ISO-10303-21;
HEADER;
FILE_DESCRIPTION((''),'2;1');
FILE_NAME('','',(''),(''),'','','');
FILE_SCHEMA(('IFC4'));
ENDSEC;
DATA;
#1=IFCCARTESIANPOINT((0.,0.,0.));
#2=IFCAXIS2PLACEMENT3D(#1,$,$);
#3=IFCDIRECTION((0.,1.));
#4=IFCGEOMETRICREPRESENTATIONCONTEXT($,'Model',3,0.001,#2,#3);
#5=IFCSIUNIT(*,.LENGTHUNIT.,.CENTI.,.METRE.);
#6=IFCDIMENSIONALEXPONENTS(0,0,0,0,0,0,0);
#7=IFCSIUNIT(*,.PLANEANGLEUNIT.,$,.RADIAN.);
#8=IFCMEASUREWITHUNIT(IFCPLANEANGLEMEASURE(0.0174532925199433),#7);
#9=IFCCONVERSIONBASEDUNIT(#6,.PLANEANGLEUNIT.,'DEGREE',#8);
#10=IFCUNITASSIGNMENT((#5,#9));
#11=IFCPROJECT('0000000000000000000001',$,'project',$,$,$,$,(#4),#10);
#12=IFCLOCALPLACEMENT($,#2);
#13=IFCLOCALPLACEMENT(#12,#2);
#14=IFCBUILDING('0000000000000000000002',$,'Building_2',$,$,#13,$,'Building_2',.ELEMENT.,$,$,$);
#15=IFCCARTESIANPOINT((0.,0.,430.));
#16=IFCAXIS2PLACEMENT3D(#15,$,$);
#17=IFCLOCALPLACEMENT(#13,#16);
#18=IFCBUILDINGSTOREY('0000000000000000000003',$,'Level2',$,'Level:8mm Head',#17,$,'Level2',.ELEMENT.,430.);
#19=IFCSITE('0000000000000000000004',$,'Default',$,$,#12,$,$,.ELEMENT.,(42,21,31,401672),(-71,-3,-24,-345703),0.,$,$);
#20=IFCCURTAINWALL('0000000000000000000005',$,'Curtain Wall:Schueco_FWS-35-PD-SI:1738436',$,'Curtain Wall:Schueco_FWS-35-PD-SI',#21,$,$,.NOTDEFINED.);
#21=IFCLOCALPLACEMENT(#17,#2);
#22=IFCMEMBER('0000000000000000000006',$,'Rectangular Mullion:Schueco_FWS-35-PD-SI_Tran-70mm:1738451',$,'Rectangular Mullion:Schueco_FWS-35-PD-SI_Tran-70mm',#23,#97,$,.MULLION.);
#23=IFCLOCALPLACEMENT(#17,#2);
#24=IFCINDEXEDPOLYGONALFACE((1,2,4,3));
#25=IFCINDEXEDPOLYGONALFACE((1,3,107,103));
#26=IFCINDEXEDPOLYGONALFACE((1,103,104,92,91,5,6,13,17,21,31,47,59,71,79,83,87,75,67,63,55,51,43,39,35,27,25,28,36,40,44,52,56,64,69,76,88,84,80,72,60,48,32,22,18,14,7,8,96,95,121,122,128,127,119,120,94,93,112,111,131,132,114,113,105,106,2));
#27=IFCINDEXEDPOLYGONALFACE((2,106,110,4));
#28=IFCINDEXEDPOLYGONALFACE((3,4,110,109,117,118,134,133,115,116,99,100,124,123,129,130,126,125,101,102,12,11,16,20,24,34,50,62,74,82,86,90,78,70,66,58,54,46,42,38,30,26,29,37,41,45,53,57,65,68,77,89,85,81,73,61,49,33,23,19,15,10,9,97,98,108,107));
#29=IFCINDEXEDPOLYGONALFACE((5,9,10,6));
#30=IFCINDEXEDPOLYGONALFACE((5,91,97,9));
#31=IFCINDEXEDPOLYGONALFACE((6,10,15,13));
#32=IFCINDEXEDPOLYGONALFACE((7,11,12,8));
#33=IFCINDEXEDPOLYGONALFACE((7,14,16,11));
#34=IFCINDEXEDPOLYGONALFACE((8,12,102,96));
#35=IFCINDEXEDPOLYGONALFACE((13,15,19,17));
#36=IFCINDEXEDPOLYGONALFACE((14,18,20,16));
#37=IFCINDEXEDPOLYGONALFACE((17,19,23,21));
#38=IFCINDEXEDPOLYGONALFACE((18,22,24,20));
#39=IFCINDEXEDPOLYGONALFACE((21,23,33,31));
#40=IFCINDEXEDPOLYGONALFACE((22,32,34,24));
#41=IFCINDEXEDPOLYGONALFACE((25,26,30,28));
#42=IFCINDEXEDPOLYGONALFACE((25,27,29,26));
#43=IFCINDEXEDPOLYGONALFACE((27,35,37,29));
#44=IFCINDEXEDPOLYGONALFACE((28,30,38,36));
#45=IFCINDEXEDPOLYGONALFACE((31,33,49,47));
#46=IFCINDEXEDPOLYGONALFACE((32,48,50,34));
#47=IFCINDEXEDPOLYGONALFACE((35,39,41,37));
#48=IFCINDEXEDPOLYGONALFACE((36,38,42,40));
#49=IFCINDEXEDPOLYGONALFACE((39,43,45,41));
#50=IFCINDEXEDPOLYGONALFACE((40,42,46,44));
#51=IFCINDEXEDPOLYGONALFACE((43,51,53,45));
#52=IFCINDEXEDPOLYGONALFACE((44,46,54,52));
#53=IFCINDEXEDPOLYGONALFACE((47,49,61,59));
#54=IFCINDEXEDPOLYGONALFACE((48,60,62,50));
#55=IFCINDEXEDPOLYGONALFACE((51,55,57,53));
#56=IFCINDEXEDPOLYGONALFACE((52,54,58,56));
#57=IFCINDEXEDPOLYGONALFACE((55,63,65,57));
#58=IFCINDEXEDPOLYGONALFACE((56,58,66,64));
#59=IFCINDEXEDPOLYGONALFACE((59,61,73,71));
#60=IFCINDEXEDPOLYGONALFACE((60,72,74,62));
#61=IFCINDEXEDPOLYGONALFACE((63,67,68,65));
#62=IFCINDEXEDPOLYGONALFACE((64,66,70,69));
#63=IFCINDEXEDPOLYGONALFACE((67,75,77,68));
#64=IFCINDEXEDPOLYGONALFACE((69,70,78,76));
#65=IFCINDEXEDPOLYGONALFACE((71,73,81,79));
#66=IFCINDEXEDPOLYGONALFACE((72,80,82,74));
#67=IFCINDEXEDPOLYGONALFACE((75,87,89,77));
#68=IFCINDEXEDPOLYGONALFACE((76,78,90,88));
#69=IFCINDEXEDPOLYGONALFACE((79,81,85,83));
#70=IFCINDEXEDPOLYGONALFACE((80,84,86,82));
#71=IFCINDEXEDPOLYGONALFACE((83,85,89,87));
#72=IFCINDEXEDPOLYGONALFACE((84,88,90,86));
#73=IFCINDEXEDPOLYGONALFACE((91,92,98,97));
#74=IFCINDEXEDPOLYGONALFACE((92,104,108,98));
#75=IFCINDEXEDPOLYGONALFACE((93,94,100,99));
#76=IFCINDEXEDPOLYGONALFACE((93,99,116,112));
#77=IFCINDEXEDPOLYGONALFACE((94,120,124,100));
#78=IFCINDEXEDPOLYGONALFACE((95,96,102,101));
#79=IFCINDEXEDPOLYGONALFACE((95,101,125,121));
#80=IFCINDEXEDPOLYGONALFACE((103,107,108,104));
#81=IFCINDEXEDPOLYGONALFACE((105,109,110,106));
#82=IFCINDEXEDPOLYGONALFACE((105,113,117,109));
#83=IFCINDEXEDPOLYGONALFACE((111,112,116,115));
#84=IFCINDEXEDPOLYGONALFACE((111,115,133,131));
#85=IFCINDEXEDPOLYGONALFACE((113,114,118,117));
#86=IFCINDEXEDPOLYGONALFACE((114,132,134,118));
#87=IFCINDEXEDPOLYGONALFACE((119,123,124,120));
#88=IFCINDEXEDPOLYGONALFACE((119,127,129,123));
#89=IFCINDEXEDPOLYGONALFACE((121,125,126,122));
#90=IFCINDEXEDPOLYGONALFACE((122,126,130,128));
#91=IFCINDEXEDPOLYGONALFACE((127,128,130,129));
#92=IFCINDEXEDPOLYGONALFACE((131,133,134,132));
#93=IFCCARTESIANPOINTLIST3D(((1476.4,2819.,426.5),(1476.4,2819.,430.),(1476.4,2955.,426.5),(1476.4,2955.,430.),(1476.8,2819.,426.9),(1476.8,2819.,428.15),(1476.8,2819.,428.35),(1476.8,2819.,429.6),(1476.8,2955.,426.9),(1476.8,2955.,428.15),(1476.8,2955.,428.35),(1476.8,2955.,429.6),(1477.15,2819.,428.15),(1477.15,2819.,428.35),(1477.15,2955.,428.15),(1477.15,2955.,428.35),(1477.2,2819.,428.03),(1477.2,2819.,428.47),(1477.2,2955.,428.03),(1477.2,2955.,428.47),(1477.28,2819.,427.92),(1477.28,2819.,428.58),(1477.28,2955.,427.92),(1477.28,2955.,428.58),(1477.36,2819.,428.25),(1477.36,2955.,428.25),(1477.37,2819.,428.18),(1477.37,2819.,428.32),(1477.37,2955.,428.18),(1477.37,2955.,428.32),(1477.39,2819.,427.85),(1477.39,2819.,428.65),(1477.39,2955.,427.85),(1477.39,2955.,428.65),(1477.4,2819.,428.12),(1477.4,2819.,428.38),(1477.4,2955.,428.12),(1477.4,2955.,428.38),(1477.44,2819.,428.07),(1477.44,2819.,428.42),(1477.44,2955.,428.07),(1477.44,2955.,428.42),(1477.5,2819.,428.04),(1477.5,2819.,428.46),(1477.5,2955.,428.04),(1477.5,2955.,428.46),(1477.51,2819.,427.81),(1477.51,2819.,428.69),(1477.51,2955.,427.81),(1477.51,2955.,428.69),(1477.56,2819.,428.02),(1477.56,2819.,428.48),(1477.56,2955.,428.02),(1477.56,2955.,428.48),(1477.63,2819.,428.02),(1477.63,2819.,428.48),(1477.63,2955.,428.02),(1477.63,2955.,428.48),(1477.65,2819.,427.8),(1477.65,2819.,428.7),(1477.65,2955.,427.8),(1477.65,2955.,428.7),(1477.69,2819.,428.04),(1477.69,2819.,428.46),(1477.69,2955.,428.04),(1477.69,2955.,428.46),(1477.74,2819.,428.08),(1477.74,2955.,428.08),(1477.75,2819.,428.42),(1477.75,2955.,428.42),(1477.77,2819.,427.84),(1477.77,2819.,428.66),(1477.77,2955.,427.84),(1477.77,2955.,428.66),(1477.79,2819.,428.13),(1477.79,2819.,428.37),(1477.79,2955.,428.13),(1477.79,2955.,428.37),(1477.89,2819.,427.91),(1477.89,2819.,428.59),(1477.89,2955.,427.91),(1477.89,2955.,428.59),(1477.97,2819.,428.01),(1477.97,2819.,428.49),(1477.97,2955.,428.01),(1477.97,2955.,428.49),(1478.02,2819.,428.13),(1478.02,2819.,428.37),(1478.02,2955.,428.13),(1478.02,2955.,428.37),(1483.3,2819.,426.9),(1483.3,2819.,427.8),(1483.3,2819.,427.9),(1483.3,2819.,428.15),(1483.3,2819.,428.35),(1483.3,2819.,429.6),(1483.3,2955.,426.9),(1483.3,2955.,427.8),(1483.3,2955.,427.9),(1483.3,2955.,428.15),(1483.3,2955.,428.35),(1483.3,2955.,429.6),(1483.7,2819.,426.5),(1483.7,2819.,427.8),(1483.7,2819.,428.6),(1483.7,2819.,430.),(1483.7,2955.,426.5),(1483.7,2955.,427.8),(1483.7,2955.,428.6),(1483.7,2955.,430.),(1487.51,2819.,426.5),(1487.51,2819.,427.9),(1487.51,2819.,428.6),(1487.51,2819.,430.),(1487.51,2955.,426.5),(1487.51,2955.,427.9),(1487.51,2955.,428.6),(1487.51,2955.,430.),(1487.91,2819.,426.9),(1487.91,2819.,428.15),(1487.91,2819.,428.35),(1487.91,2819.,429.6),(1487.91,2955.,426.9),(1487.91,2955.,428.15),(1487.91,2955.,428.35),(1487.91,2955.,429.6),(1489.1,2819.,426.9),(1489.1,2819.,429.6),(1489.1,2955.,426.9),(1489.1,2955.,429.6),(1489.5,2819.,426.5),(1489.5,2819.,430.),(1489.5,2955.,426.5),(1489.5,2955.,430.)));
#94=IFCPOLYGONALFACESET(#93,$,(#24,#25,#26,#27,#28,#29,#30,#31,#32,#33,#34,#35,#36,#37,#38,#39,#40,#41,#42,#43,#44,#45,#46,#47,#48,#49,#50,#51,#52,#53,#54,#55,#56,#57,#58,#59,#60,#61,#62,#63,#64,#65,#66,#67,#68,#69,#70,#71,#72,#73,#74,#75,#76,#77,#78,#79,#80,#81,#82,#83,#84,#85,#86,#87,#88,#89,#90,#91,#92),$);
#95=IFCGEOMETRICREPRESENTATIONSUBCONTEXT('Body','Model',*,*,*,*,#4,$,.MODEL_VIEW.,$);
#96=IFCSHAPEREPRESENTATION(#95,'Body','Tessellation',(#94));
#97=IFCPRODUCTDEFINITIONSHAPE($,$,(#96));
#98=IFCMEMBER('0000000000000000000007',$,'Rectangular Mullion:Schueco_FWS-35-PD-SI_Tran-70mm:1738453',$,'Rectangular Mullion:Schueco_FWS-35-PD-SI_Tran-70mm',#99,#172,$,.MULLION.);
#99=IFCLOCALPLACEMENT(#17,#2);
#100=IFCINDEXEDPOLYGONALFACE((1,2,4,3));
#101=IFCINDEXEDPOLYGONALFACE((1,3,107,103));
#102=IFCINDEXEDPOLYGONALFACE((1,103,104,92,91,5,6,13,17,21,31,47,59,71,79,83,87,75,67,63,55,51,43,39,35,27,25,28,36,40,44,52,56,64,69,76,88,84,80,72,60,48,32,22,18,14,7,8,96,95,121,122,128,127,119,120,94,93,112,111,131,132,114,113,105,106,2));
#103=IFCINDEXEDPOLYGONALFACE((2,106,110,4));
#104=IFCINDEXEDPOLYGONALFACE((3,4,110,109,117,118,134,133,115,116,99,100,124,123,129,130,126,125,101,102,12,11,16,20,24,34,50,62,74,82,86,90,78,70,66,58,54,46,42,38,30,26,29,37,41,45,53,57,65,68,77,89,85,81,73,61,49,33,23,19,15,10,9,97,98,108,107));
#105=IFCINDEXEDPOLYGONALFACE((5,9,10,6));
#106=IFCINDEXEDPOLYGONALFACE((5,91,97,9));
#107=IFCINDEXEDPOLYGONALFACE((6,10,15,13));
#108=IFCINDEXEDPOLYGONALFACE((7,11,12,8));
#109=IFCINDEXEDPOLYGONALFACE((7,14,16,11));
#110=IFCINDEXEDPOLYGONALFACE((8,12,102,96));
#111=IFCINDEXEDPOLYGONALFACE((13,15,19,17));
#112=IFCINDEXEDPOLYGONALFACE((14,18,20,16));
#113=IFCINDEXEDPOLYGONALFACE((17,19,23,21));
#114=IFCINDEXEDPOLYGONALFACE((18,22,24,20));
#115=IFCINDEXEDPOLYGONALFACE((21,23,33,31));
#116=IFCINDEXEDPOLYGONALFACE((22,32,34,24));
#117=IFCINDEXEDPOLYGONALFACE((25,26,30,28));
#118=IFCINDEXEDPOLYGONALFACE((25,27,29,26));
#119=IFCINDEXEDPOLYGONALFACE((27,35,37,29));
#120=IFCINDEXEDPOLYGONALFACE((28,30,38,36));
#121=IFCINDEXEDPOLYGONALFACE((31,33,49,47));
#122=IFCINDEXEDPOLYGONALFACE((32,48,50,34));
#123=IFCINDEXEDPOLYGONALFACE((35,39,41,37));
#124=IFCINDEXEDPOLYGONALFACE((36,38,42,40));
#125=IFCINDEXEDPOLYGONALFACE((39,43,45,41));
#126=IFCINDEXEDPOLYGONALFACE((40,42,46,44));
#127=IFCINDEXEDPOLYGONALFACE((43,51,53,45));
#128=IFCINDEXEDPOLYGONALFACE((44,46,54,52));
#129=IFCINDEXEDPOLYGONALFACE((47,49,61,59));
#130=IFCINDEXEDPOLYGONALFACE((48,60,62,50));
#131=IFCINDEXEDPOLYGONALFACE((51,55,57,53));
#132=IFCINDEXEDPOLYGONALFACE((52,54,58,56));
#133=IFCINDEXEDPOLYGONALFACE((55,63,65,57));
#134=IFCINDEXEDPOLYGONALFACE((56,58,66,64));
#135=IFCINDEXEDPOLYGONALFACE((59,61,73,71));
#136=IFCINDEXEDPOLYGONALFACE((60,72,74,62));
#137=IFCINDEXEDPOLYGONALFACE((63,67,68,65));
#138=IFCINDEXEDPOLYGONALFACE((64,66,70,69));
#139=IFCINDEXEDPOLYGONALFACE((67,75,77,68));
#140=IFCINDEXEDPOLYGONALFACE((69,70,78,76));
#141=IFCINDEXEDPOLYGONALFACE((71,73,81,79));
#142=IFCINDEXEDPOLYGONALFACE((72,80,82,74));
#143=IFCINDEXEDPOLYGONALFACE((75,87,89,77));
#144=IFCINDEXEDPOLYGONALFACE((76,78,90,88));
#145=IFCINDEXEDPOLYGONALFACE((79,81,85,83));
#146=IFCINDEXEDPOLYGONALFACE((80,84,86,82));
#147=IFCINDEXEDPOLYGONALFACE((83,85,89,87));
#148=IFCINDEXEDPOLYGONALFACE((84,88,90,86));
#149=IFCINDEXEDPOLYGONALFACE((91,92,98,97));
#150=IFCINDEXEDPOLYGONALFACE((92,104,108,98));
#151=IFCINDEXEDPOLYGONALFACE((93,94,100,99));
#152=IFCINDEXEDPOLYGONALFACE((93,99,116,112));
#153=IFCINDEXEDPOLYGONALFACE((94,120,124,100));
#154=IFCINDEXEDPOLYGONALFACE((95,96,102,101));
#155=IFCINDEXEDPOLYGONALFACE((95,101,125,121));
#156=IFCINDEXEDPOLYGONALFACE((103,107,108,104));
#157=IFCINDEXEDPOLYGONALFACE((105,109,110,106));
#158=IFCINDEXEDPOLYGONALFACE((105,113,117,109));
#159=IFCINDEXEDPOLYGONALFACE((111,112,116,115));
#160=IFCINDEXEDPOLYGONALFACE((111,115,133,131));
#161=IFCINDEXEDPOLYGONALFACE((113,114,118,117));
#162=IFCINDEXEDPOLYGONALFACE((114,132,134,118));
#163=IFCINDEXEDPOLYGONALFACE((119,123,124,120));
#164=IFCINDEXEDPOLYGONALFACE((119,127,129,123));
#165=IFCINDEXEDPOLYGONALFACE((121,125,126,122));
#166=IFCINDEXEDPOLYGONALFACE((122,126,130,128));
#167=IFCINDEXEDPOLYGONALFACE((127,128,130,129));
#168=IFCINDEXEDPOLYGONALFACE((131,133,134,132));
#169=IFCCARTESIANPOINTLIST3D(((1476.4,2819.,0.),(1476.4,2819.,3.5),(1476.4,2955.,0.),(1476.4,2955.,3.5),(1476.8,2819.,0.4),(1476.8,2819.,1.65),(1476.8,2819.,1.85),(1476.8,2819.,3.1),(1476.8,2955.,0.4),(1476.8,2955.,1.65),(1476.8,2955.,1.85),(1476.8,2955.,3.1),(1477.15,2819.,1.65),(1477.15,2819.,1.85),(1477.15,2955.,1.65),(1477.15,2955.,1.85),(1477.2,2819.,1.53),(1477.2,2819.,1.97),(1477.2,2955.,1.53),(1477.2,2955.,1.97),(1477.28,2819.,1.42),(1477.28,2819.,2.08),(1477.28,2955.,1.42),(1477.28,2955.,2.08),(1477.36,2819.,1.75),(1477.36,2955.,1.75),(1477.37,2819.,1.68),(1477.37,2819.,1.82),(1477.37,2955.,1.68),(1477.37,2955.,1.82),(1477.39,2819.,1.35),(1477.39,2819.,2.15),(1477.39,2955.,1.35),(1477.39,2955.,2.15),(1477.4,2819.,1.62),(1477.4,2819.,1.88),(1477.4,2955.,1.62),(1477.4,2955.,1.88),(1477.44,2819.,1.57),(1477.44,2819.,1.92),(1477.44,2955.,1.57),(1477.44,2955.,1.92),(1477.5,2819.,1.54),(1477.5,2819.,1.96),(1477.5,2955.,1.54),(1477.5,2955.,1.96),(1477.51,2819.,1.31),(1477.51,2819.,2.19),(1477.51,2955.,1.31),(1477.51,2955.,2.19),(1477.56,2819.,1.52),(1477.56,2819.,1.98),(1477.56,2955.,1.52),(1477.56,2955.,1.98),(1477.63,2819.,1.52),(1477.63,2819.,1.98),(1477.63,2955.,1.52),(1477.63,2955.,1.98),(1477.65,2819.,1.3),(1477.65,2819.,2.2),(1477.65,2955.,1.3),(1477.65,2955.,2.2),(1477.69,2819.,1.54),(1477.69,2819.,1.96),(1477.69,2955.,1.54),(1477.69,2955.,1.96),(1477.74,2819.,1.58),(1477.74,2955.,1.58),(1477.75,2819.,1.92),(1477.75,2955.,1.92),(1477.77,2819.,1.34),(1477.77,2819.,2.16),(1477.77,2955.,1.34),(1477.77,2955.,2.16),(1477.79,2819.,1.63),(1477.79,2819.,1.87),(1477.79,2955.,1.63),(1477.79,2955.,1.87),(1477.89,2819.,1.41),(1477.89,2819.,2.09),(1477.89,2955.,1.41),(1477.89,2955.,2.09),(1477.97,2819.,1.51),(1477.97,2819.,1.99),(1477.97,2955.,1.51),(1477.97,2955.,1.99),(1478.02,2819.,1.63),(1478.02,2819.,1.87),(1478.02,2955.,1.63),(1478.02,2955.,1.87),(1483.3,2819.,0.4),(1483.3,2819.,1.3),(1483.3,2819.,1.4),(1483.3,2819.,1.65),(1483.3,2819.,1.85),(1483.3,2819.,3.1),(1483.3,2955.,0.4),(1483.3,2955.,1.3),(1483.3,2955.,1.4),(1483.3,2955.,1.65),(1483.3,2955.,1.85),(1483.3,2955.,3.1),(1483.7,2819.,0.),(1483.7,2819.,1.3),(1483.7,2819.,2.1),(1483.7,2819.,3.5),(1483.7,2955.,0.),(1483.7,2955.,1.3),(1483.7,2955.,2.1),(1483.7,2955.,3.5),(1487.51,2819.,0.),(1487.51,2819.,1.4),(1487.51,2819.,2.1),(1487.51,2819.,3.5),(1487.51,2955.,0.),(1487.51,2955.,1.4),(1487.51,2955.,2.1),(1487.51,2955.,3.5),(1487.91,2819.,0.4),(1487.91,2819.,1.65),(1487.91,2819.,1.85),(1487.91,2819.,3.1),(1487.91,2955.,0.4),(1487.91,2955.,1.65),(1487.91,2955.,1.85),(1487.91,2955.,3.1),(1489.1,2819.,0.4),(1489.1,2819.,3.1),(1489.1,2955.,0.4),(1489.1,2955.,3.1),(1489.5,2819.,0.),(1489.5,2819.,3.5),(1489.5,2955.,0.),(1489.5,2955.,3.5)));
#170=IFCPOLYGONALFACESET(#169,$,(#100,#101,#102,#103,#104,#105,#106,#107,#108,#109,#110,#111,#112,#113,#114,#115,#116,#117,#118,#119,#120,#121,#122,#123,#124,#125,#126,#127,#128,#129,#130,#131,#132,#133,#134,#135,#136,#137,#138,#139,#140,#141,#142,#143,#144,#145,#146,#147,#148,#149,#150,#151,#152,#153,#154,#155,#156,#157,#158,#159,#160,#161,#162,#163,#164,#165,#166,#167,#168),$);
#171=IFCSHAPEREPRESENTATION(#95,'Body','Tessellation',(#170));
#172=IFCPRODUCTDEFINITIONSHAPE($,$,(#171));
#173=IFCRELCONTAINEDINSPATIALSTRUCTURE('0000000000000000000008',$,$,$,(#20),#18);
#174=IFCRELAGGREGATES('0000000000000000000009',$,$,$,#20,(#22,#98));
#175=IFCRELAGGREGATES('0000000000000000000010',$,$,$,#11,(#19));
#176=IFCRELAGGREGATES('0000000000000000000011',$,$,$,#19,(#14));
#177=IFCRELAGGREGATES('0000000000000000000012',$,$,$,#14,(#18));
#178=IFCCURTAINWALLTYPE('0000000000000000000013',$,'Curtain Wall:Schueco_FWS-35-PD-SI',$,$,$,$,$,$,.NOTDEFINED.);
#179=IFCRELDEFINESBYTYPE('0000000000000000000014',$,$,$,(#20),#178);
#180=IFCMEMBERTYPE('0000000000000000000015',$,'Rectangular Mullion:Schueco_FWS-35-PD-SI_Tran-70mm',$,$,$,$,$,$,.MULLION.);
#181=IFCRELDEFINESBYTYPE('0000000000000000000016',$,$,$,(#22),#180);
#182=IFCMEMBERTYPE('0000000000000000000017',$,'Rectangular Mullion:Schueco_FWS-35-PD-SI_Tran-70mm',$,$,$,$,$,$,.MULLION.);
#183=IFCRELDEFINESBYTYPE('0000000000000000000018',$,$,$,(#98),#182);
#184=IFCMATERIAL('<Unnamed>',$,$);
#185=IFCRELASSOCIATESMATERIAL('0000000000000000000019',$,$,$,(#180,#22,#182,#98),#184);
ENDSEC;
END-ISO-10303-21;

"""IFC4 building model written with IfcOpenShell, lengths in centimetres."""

from ifc_helpers import new_model, entity, si_unit, converted_unit, direction, frame, origin, place, context, subcontext, project, spatial, line, arc, indexed_curve, outline, extrude, source, transform, mapped, material, type_object, type_shapes, element, aggregate, save


model = new_model("IFC4")

# Units and contexts
model_context = context("Model", 3, precision=0.001, world=origin(), true_north=direction((0.0, 1.0)))
body_context = subcontext(model_context, "Body", "Model", "MODEL_VIEW")
ifc_project = project(units=[si_unit("LENGTHUNIT", "METRE", prefix="CENTI"), converted_unit("PLANEANGLEUNIT", "DEGREE", entity("IfcPlaneAngleMeasure", 0.0174532925199433), si_unit("PLANEANGLEUNIT", "RADIAN"), dimensions=[0, 0, 0, 0, 0, 0, 0])], contexts=[model_context])

# Site, building, storey
site_placement = place(None, origin())
site = spatial("IfcSite", under=ifc_project, at=site_placement, Name="Default", CompositionType="ELEMENT", RefLatitude=(42, 21, 31, 401672), RefLongitude=(-71, -3, -24, -345703), RefElevation=0.0)
building_placement = place(site_placement, origin())
building = spatial("IfcBuilding", under=site, at=building_placement, Name="Building_2", LongName="Building_2", CompositionType="ELEMENT")
storey_placement = place(building_placement, frame((0.0, 0.0, 430.0)))
storey = spatial("IfcBuildingStorey", under=building, at=storey_placement, Name="Level2", ObjectType="Level:8mm Head", LongName="Level2", CompositionType="ELEMENT", Elevation=430.0)

# Curtain wall, members
curtain_wall_type = type_object("IfcCurtainWallType", Name="Curtain Wall:Schueco_FWS-35-PD-SI", PredefinedType="NOTDEFINED")
curtain_wall_placement = place(storey_placement, frame((0.0, 0.0, -430.0)))
curtain_wall = element("IfcCurtainWall", 1, at=curtain_wall_placement, inside=storey, type_object=curtain_wall_type, Name="Curtain Wall:Schueco_FWS-35-PD-SI:1738436", ObjectType="Curtain Wall:Schueco_FWS-35-PD-SI", PredefinedType="NOTDEFINED")
ifc_material_1 = material(Name="<Unnamed>")
member_type_1 = type_object("IfcMemberType", Name="Rectangular Mullion:Schueco_FWS-35-PD-SI_Tran-70mm", PredefinedType="MULLION", material=ifc_material_1)
shared_shape_1 = source(origin(), body_context, "Body", "SweptSolid", [
    extrude(outline(indexed_curve([(-1.78, -6.52), (1.72, -6.52), (1.72, 0.78), (0.42, 0.78), (0.42, 0.38), (1.32, 0.38), (1.32, -6.12), (0.07, -6.12), (0.07, -5.77), (0.42, -5.34), (0.09, -4.9), (0.09, -5.14), (-0.03, -5.56), (-0.15, -5.14), (-0.15, -4.9), (-0.48, -5.34), (-0.13, -5.77), (-0.13, -6.12), (-1.38, -6.12), (-1.38, 0.38), (-0.13, 0.38), (-0.13, 4.99), (-1.38, 4.99), (-1.38, 6.18), (1.32, 6.18), (1.32, 4.99), (0.07, 4.99), (0.07, 0.38), (0.32, 0.38), (0.32, 4.59), (1.72, 4.59), (1.72, 6.58), (-1.78, 6.58), (-1.78, 4.59), (-0.38, 4.59), (-0.38, 0.78), (-1.78, 0.78)], segments=[line(1, 2, 3, 4, 5, 6, 7, 8, 9), arc(9, 10, 11), line(11, 12), arc(12, 13, 14), line(14, 15), arc(15, 16, 17), line(17, 18, 19, 20, 21, 22, 23, 24, 25, 26, 27, 28, 29, 30, 31, 32, 33, 34, 35, 36, 37, 1)], self_intersect=False)), frame((-1.78, 4.58, -136.0), z_axis=(0.0, 0.0, 1.0), x_axis=(-1.0, 0.0, 0.0)), (0.0, 0.0, 1.0), 136.0),
])
type_shapes(member_type_1, [shared_shape_1])
member_1_placement = place(curtain_wall_placement, frame((1487.5, 2819.0, 860.0), z_axis=(0.0, -1.0, 0.0), x_axis=(0.0, 0.0, 1.0)))
member_1 = element("IfcMember", 2, at=member_1_placement, type_object=member_type_1, material=ifc_material_1, Name="Rectangular Mullion:Schueco_FWS-35-PD-SI_Tran-70mm:1738451", ObjectType="Rectangular Mullion:Schueco_FWS-35-PD-SI_Tran-70mm", PredefinedType="MULLION", context=body_context, shape_type="MappedRepresentation", body=[
    mapped(shared_shape_1, transform((0.0, 0.0, 0.0), scale=1.0)),
])
member_type_2 = type_object("IfcMemberType", Name="Rectangular Mullion:Schueco_FWS-35-PD-SI_Tran-70mm", PredefinedType="MULLION", material=ifc_material_1)
shared_shape_2 = source(origin(), body_context, "Body", "SweptSolid", [
    extrude(outline(indexed_curve([(-6.52, -1.78), (0.78, -1.78), (0.78, -0.38), (4.59, -0.38), (4.59, -1.78), (6.58, -1.78), (6.58, 1.72), (4.59, 1.72), (4.59, 0.32), (0.38, 0.32), (0.38, 0.07), (4.99, 0.07), (4.99, 1.32), (6.18, 1.32), (6.18, -1.38), (4.99, -1.38), (4.99, -0.13), (0.38, -0.13), (0.38, -1.38), (-6.12, -1.38), (-6.12, -0.13), (-5.77, -0.13), (-5.34, -0.48), (-4.9, -0.15), (-5.14, -0.15), (-5.56, -0.03), (-5.14, 0.09), (-4.9, 0.09), (-5.34, 0.42), (-5.77, 0.07), (-6.12, 0.07), (-6.12, 1.32), (0.38, 1.32), (0.38, 0.42), (0.78, 0.42), (0.78, 1.72), (-6.52, 1.72)], segments=[line(1, 2, 3, 4, 5, 6, 7, 8, 9, 10, 11, 12, 13, 14, 15, 16, 17, 18, 19, 20, 21, 22), arc(22, 23, 24), line(24, 25), arc(25, 26, 27), line(27, 28), arc(28, 29, 30), line(30, 31, 32, 33, 34, 35, 36, 37, 1)], self_intersect=False)), frame((-1.72, 4.58, -136.0), z_axis=(0.0, 0.0, 1.0), x_axis=(0.0, -1.0, 0.0)), (0.0, 0.0, 1.0), 136.0),
])
type_shapes(member_type_2, [shared_shape_2])
member_2_placement = place(curtain_wall_placement, frame((1487.5, 2955.0, 430.0), z_axis=(0.0, 1.0, 0.0), x_axis=(0.0, 0.0, -1.0)))
member_2 = element("IfcMember", 3, at=member_2_placement, type_object=member_type_2, material=ifc_material_1, Name="Rectangular Mullion:Schueco_FWS-35-PD-SI_Tran-70mm:1738453", ObjectType="Rectangular Mullion:Schueco_FWS-35-PD-SI_Tran-70mm", PredefinedType="MULLION", context=body_context, shape_type="MappedRepresentation", body=[
    mapped(shared_shape_2, transform((0.0, 0.0, 0.0), scale=1.0)),
])
aggregate(curtain_wall, [member_1, member_2])

save(model, "model.ifc")
